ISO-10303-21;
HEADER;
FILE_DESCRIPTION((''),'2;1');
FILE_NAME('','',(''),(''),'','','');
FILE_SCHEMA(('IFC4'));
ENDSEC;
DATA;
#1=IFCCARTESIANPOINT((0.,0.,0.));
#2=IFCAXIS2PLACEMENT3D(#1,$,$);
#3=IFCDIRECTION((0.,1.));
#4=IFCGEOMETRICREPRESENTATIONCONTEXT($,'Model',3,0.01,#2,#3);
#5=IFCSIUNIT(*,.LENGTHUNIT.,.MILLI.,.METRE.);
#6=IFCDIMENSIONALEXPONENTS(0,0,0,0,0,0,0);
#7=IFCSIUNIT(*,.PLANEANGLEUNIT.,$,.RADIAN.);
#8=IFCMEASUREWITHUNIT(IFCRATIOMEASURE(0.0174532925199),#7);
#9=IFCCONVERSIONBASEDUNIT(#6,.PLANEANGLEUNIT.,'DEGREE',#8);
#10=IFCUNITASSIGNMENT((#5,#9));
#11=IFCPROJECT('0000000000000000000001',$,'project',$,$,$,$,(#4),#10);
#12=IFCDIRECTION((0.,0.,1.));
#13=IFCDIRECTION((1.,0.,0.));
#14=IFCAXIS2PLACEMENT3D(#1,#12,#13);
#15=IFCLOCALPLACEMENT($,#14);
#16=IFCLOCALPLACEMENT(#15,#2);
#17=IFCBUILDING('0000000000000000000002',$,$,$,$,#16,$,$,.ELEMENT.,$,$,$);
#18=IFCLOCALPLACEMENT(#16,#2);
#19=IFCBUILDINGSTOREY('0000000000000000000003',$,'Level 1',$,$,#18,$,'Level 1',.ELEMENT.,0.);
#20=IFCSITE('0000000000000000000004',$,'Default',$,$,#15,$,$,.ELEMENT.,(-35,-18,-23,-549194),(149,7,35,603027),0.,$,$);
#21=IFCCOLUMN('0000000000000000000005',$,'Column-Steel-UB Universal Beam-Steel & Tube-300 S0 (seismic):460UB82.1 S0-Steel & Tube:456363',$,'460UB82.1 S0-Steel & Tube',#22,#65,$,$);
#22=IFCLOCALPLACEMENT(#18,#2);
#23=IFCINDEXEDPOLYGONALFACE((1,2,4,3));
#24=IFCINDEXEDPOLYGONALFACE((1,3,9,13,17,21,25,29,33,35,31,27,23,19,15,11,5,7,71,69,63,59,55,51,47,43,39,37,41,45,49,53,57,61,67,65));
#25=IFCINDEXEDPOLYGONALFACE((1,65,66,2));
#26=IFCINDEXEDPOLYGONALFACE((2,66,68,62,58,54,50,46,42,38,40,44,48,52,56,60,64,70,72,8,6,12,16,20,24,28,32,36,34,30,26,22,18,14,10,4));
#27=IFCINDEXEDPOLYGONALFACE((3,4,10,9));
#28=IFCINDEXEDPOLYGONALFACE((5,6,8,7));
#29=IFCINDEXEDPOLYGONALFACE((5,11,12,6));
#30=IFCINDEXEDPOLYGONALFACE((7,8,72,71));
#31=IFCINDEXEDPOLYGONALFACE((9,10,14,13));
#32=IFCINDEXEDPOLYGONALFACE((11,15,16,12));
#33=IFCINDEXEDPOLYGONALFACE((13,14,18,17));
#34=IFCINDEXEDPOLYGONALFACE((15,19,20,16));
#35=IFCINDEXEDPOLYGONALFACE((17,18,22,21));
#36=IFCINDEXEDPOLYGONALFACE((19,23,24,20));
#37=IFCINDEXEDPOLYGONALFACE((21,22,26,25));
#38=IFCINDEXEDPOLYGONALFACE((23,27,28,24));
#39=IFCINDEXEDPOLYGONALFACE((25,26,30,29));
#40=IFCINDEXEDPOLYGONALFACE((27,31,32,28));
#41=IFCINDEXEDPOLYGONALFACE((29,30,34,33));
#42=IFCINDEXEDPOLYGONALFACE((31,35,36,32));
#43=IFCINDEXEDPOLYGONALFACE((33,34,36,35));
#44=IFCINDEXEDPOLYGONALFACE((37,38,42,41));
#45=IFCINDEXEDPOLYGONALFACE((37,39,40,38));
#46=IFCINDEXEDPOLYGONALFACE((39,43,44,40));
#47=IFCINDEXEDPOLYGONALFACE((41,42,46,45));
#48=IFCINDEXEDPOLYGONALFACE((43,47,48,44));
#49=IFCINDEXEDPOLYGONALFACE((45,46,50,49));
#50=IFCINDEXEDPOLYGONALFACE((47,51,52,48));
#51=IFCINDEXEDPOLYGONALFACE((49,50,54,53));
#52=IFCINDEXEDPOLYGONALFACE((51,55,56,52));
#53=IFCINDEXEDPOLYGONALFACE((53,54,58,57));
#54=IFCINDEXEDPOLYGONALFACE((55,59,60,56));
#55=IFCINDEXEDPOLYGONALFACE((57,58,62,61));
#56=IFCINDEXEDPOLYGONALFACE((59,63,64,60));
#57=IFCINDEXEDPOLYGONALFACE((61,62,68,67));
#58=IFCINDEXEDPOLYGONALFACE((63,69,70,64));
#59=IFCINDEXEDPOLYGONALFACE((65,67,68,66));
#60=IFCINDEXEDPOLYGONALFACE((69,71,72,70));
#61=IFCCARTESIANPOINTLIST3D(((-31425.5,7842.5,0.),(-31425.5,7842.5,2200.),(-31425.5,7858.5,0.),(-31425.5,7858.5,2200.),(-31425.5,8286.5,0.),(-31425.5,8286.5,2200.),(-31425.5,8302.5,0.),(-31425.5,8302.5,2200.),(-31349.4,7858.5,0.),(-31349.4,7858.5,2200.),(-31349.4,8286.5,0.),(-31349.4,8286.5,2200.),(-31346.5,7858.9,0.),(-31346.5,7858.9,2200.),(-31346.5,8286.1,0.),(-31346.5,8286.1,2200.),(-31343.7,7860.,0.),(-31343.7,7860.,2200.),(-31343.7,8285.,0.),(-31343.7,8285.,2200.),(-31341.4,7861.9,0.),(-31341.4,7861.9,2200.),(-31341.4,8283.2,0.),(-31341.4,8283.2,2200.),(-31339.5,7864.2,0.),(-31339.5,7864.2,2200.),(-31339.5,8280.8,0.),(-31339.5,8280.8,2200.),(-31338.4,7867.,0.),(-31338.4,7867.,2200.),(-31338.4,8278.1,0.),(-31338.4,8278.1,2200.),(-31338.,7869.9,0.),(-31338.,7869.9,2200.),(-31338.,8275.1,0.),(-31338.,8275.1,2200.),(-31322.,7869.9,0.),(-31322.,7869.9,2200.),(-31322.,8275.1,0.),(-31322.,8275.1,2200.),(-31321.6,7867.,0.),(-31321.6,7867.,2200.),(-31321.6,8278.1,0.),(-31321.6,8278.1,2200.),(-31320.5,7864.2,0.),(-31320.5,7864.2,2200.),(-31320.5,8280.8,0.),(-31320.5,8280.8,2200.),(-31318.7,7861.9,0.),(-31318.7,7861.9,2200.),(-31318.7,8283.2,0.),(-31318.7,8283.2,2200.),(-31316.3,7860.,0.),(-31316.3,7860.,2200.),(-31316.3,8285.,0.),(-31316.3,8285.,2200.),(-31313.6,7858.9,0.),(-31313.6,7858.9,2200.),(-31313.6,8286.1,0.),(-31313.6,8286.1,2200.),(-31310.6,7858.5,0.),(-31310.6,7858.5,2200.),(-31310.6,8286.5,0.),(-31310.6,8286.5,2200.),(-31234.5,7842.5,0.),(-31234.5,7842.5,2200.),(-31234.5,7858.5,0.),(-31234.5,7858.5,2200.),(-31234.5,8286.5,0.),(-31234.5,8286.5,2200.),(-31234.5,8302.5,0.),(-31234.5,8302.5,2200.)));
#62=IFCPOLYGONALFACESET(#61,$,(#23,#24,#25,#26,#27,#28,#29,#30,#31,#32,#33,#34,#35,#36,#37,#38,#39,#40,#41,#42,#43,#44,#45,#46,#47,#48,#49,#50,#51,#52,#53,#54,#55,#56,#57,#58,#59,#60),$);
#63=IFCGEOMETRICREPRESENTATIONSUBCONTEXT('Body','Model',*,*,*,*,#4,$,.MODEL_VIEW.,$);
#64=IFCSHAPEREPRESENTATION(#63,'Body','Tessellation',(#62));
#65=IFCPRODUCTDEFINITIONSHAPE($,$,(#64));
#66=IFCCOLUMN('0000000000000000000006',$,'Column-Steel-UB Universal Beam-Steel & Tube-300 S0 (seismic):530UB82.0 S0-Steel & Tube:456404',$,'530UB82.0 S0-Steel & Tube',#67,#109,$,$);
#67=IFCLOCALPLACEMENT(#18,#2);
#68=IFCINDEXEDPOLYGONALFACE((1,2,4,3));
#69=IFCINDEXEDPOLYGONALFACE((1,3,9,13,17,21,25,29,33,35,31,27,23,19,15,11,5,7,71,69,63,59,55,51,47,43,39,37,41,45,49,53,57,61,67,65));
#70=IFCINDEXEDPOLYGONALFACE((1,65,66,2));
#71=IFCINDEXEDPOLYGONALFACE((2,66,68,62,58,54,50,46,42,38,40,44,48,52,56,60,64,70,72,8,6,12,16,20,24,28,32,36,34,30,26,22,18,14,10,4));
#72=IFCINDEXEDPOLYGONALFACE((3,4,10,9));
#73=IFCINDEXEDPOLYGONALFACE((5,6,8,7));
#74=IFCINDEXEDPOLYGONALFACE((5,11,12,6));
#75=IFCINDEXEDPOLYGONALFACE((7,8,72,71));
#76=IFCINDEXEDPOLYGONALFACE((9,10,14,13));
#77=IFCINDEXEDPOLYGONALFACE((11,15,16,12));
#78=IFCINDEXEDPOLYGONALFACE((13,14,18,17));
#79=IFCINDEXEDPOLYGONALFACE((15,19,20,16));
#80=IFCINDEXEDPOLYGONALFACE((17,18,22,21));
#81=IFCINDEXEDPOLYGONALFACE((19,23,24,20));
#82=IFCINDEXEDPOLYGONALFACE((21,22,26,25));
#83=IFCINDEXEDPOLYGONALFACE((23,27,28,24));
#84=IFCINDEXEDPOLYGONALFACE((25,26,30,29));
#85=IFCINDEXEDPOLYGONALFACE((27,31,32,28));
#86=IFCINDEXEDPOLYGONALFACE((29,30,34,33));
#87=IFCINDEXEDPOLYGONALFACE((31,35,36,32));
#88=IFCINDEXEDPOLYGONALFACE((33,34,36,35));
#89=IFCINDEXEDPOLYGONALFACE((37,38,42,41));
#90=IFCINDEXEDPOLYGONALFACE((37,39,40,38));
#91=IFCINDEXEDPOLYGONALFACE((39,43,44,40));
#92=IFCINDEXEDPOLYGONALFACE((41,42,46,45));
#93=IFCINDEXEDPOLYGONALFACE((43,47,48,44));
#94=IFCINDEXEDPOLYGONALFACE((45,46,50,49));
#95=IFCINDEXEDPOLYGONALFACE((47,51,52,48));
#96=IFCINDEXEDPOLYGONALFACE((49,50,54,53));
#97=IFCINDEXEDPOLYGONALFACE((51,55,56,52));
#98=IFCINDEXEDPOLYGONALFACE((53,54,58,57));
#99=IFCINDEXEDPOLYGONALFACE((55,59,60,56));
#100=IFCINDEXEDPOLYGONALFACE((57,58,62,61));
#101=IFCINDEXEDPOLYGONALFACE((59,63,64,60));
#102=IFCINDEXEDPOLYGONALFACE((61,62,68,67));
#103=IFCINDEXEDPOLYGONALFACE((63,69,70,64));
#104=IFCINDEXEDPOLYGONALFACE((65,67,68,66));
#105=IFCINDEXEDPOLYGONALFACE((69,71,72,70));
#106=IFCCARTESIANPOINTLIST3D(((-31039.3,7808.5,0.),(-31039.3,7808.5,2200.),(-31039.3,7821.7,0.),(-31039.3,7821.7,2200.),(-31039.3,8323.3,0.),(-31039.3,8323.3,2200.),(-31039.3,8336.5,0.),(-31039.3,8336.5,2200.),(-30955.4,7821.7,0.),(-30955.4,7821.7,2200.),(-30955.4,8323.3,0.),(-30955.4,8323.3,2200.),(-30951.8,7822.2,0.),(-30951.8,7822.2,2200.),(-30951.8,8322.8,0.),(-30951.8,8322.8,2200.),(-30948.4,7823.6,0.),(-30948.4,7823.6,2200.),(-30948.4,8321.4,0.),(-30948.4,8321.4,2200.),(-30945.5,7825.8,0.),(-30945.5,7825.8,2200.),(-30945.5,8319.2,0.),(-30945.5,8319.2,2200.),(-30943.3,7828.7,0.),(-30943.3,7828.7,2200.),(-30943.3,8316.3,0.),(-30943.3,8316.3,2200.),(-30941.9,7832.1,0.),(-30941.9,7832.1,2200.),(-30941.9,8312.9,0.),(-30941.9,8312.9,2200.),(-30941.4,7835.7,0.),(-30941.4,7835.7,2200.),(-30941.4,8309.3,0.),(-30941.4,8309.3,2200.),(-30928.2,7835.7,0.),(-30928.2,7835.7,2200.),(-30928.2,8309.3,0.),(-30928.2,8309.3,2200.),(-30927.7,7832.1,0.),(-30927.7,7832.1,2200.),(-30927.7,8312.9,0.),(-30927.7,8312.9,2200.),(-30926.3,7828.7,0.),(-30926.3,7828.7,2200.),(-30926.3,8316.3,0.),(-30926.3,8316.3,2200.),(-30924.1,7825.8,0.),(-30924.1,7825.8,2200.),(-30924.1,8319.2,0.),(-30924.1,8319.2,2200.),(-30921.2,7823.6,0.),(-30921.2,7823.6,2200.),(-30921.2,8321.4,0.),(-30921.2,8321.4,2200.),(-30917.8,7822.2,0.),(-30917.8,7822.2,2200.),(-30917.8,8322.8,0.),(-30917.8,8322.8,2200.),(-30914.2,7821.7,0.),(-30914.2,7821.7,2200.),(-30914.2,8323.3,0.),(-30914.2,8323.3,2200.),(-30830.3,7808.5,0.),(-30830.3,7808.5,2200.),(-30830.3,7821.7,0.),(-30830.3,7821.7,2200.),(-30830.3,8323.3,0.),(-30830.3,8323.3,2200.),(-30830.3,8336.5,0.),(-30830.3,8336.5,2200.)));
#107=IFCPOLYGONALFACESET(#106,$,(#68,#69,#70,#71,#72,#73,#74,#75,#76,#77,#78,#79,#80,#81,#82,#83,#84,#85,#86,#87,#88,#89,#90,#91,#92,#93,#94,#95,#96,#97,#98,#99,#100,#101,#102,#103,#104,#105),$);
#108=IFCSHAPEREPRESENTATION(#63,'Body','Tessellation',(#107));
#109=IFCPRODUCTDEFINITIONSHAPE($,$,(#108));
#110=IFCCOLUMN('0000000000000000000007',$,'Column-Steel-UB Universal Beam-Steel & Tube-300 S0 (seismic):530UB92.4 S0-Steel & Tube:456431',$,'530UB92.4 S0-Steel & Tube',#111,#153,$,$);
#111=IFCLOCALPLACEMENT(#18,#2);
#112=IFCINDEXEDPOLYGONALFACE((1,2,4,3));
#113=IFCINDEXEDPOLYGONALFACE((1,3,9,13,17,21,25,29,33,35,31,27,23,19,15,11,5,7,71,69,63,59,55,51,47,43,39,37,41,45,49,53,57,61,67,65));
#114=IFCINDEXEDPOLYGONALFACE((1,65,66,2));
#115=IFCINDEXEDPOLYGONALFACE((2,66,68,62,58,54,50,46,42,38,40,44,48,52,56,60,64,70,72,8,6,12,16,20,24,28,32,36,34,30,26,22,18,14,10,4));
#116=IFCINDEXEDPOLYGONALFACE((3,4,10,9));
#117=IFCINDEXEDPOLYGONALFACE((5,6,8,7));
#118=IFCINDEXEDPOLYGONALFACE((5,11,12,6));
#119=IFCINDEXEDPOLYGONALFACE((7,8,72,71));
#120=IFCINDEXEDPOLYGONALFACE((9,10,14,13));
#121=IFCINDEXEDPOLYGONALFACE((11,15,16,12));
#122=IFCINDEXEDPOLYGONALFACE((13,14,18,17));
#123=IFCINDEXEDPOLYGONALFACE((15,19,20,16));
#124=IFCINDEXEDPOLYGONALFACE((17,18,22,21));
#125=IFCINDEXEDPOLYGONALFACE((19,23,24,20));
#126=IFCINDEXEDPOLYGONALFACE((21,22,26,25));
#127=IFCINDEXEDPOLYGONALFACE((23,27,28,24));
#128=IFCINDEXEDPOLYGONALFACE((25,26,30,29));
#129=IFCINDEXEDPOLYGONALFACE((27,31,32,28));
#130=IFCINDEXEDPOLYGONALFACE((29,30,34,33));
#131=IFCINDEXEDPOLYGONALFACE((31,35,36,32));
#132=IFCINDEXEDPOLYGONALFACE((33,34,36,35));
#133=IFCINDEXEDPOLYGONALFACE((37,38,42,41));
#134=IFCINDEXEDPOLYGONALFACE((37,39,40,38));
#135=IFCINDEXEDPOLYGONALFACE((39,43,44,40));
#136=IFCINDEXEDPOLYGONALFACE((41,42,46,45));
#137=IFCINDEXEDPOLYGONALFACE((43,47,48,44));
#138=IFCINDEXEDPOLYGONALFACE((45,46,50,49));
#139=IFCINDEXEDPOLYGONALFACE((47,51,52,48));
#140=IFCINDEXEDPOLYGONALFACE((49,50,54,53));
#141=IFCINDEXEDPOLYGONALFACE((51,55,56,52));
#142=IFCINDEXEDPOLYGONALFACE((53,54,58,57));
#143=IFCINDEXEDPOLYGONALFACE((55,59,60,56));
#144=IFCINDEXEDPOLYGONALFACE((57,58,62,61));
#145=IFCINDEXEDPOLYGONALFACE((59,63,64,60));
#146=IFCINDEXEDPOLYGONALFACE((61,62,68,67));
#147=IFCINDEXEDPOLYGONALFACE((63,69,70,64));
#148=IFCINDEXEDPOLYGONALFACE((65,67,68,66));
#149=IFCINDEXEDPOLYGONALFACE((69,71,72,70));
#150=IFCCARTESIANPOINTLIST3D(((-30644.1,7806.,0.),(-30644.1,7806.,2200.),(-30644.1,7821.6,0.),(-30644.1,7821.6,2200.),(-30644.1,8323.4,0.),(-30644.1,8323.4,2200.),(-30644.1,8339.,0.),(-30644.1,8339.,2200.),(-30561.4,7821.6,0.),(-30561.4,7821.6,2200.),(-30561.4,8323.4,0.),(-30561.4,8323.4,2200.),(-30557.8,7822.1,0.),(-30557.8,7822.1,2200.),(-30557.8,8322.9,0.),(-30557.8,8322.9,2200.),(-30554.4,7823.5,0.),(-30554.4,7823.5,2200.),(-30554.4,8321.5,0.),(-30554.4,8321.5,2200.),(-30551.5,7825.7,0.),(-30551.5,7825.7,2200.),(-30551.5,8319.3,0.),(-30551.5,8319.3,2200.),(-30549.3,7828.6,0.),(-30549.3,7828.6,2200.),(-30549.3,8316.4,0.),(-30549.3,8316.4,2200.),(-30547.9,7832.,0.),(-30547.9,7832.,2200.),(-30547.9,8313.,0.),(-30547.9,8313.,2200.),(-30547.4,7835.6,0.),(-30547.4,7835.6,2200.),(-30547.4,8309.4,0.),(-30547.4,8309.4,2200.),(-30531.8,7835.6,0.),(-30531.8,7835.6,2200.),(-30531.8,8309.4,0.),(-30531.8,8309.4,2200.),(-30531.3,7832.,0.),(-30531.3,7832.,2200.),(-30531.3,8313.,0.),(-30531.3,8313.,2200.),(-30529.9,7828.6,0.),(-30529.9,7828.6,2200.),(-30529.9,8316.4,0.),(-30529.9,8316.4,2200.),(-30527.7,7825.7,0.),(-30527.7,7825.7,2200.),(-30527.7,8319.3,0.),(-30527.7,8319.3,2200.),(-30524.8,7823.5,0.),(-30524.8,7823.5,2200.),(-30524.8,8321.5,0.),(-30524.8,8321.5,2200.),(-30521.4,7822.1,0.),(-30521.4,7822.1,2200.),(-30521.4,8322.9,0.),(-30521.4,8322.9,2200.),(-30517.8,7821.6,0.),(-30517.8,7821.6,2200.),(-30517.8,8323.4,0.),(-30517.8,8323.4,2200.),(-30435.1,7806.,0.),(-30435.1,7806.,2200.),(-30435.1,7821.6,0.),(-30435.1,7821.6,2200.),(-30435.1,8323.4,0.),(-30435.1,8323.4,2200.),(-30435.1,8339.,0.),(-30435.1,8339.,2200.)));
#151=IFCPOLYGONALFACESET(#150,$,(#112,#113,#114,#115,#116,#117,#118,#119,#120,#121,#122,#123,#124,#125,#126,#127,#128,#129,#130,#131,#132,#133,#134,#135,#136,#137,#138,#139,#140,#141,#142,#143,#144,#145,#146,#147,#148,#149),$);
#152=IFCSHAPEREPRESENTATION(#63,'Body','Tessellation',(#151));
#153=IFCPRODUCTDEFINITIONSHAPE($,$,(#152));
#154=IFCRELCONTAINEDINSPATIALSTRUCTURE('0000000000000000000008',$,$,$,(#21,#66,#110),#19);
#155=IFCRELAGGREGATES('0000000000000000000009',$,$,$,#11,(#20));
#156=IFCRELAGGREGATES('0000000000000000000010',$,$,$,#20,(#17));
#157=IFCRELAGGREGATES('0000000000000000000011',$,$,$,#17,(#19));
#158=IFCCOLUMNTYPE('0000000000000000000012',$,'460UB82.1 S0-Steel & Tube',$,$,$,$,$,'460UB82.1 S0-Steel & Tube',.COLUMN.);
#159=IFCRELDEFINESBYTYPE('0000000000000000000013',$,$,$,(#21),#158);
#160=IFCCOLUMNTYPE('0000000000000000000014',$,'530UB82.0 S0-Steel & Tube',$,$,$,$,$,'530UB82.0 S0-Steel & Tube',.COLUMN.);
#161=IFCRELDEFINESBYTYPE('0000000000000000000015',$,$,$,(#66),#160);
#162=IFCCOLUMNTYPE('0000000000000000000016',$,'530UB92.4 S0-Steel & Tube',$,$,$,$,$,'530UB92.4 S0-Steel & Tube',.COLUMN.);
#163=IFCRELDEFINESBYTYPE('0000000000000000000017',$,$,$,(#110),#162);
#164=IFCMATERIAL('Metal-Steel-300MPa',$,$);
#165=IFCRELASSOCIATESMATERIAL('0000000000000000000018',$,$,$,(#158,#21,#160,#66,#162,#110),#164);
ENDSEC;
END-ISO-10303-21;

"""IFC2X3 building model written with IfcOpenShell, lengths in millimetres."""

from ifc_helpers import new_model, entity, si_unit, converted_unit, direction, frame, frame_2d, origin, origin_with_axes, place, context, subcontext, project, spatial, polyline, circle_curve, parameter, trimmed, segment, composite_curve, outline, extrude, source, transform, mapped, material, type_object, type_shapes, element, save


model = new_model("IFC2X3")

# Units and contexts
model_context = context("Model", 3, precision=0.01, world=origin(), true_north=direction((0.0, 1.0)))
body_context = subcontext(model_context, "Body", "Model", "MODEL_VIEW")
ifc_project = project(units=[si_unit("LENGTHUNIT", "METRE", prefix="MILLI"), converted_unit("PLANEANGLEUNIT", "DEGREE", entity("IfcRatioMeasure", 0.0174532925199), si_unit("PLANEANGLEUNIT", "RADIAN"), dimensions=[0, 0, 0, 0, 0, 0, 0])], contexts=[model_context])

# Site, building, storey
site_placement = place(None, origin_with_axes())
site = spatial("IfcSite", under=ifc_project, at=site_placement, Name="Default", CompositionType="ELEMENT", RefLatitude=(-35, -18, -23, -549194), RefLongitude=(149, 7, 35, 603027), RefElevation=0.0)
building_placement = place(site_placement, origin())
building = spatial("IfcBuilding", under=site, at=building_placement, CompositionType="ELEMENT")
storey_placement = place(building_placement, origin())
storey = spatial("IfcBuildingStorey", under=building, at=storey_placement, Name="Level 1", LongName="Level 1", CompositionType="ELEMENT", Elevation=0.0)

# Columns
ifc_material = material(Name="Metal-Steel-300MPa")
column_type_1 = type_object("IfcColumnType", Name="460UB82.1 S0-Steel & Tube", ElementType="460UB82.1 S0-Steel & Tube", PredefinedType="COLUMN", material=ifc_material)
shared_shape_1 = source(origin(), body_context, "Body", "SweptSolid", [
    extrude(outline(composite_curve([segment(polyline([(214.0, -95.5), (230.0, -95.5)]), True, "CONTINUOUS"), segment(polyline([(230.0, -95.5), (230.0, 95.5)]), True, "CONTINUOUS"), segment(polyline([(230.0, 95.5), (214.0, 95.5)]), True, "CONTINUOUS"), segment(polyline([(214.0, 95.5), (214.0, 19.4)]), True, "CONTINUOUS"), segment(trimmed(circle_curve(frame_2d((202.6, 19.4), x_axis=(1.0, 0.0)), 11.4), [parameter(270.0)], [parameter(0.0)], True, "PARAMETER"), False, "CONTINUOUS"), segment(polyline([(202.6, 8.0), (-202.6, 8.0)]), True, "CONTINUOUS"), segment(trimmed(circle_curve(frame_2d((-202.6, 19.4), x_axis=(0.0, -1.0)), 11.4), [parameter(270.0)], [parameter(0.0)], True, "PARAMETER"), False, "CONTINUOUS"), segment(polyline([(-214.0, 19.4), (-214.0, 95.5)]), True, "CONTINUOUS"), segment(polyline([(-214.0, 95.5), (-230.0, 95.5)]), True, "CONTINUOUS"), segment(polyline([(-230.0, 95.5), (-230.0, -95.5)]), True, "CONTINUOUS"), segment(polyline([(-230.0, -95.5), (-214.0, -95.5)]), True, "CONTINUOUS"), segment(polyline([(-214.0, -95.5), (-214.0, -19.4)]), True, "CONTINUOUS"), segment(trimmed(circle_curve(frame_2d((-202.6, -19.4), x_axis=(-1.0, 0.0)), 11.4), [parameter(270.0)], [parameter(0.0)], True, "PARAMETER"), False, "CONTINUOUS"), segment(polyline([(-202.6, -8.0), (202.6, -8.0)]), True, "CONTINUOUS"), segment(trimmed(circle_curve(frame_2d((202.6, -19.4), x_axis=(0.0, 1.0)), 11.4), [parameter(270.0)], [parameter(0.0)], True, "PARAMETER"), False, "CONTINUOUS"), segment(polyline([(214.0, -19.4), (214.0, -95.5)]), True, "CONTINUOUS")], self_intersect=False)), frame((0.0, 0.0, 0.0), z_axis=(0.0, 0.0, 1.0), x_axis=(0.0, -1.0, 0.0)), (0.0, 0.0, 1.0), 2200.0),
])
type_shapes(column_type_1, [shared_shape_1])
column_1_placement = place(storey_placement, frame((-31330.0, 8072.5, 0.0)))
element("IfcColumn", 1, at=column_1_placement, inside=storey, type_object=column_type_1, material=ifc_material, Name="Column-Steel-UB Universal Beam-Steel & Tube-300 S0 (seismic):460UB82.1 S0-Steel & Tube:456363", ObjectType="460UB82.1 S0-Steel & Tube", context=body_context, shape_type="MappedRepresentation", body=[
    mapped(shared_shape_1, transform((0.0, 0.0, 0.0), scale=1.0)),
])
column_type_2 = type_object("IfcColumnType", Name="530UB82.0 S0-Steel & Tube", ElementType="530UB82.0 S0-Steel & Tube", PredefinedType="COLUMN", material=ifc_material)
shared_shape_2 = source(origin(), body_context, "Body", "SweptSolid", [
    extrude(outline(composite_curve([segment(polyline([(250.8, -104.5), (264.0, -104.5)]), True, "CONTINUOUS"), segment(polyline([(264.0, -104.5), (264.0, 104.5)]), True, "CONTINUOUS"), segment(polyline([(264.0, 104.5), (250.8, 104.5)]), True, "CONTINUOUS"), segment(polyline([(250.8, 104.5), (250.8, 20.6)]), True, "CONTINUOUS"), segment(trimmed(circle_curve(frame_2d((236.8, 20.6), x_axis=(1.0, 0.0)), 14.0), [parameter(270.0)], [parameter(0.0)], True, "PARAMETER"), False, "CONTINUOUS"), segment(polyline([(236.8, 6.6), (-236.8, 6.6)]), True, "CONTINUOUS"), segment(trimmed(circle_curve(frame_2d((-236.8, 20.6), x_axis=(0.0, -1.0)), 14.0), [parameter(270.0)], [parameter(0.0)], True, "PARAMETER"), False, "CONTINUOUS"), segment(polyline([(-250.8, 20.6), (-250.8, 104.5)]), True, "CONTINUOUS"), segment(polyline([(-250.8, 104.5), (-264.0, 104.5)]), True, "CONTINUOUS"), segment(polyline([(-264.0, 104.5), (-264.0, -104.5)]), True, "CONTINUOUS"), segment(polyline([(-264.0, -104.5), (-250.8, -104.5)]), True, "CONTINUOUS"), segment(polyline([(-250.8, -104.5), (-250.8, -20.6)]), True, "CONTINUOUS"), segment(trimmed(circle_curve(frame_2d((-236.8, -20.6), x_axis=(-1.0, 0.0)), 14.0), [parameter(270.0)], [parameter(0.0)], True, "PARAMETER"), False, "CONTINUOUS"), segment(polyline([(-236.8, -6.6), (236.8, -6.6)]), True, "CONTINUOUS"), segment(trimmed(circle_curve(frame_2d((236.8, -20.6), x_axis=(0.0, 1.0)), 14.0), [parameter(270.0)], [parameter(0.0)], True, "PARAMETER"), False, "CONTINUOUS"), segment(polyline([(250.8, -20.6), (250.8, -104.5)]), True, "CONTINUOUS")], self_intersect=False)), frame((0.0, 0.0, 0.0), z_axis=(0.0, 0.0, 1.0), x_axis=(0.0, -1.0, 0.0)), (0.0, 0.0, 1.0), 2200.0),
])
type_shapes(column_type_2, [shared_shape_2])
column_2_placement = place(storey_placement, frame((-30934.8, 8072.5, 0.0)))
element("IfcColumn", 2, at=column_2_placement, inside=storey, type_object=column_type_2, material=ifc_material, Name="Column-Steel-UB Universal Beam-Steel & Tube-300 S0 (seismic):530UB82.0 S0-Steel & Tube:456404", ObjectType="530UB82.0 S0-Steel & Tube", context=body_context, shape_type="MappedRepresentation", body=[
    mapped(shared_shape_2, transform((0.0, 0.0, 0.0), scale=1.0)),
])
column_type_3 = type_object("IfcColumnType", Name="530UB92.4 S0-Steel & Tube", ElementType="530UB92.4 S0-Steel & Tube", PredefinedType="COLUMN", material=ifc_material)
shared_shape_3 = source(origin(), body_context, "Body", "SweptSolid", [
    extrude(outline(composite_curve([segment(polyline([(250.9, -104.5), (266.5, -104.5)]), True, "CONTINUOUS"), segment(polyline([(266.5, -104.5), (266.5, 104.5)]), True, "CONTINUOUS"), segment(polyline([(266.5, 104.5), (250.9, 104.5)]), True, "CONTINUOUS"), segment(polyline([(250.9, 104.5), (250.9, 21.8)]), True, "CONTINUOUS"), segment(trimmed(circle_curve(frame_2d((236.9, 21.8), x_axis=(1.0, 0.0)), 14.0), [parameter(270.0)], [parameter(0.0)], True, "PARAMETER"), False, "CONTINUOUS"), segment(polyline([(236.9, 7.8), (-236.9, 7.8)]), True, "CONTINUOUS"), segment(trimmed(circle_curve(frame_2d((-236.9, 21.8), x_axis=(0.0, -1.0)), 14.0), [parameter(270.0)], [parameter(0.0)], True, "PARAMETER"), False, "CONTINUOUS"), segment(polyline([(-250.9, 21.8), (-250.9, 104.5)]), True, "CONTINUOUS"), segment(polyline([(-250.9, 104.5), (-266.5, 104.5)]), True, "CONTINUOUS"), segment(polyline([(-266.5, 104.5), (-266.5, -104.5)]), True, "CONTINUOUS"), segment(polyline([(-266.5, -104.5), (-250.9, -104.5)]), True, "CONTINUOUS"), segment(polyline([(-250.9, -104.5), (-250.9, -21.8)]), True, "CONTINUOUS"), segment(trimmed(circle_curve(frame_2d((-236.9, -21.8), x_axis=(-1.0, 0.0)), 14.0), [parameter(270.0)], [parameter(0.0)], True, "PARAMETER"), False, "CONTINUOUS"), segment(polyline([(-236.9, -7.8), (236.9, -7.8)]), True, "CONTINUOUS"), segment(trimmed(circle_curve(frame_2d((236.9, -21.8), x_axis=(0.0, 1.0)), 14.0), [parameter(270.0)], [parameter(0.0)], True, "PARAMETER"), False, "CONTINUOUS"), segment(polyline([(250.9, -21.8), (250.9, -104.5)]), True, "CONTINUOUS")], self_intersect=False)), frame((0.0, 0.0, 0.0), z_axis=(0.0, 0.0, 1.0), x_axis=(0.0, -1.0, 0.0)), (0.0, 0.0, 1.0), 2200.0),
])
type_shapes(column_type_3, [shared_shape_3])
column_3_placement = place(storey_placement, frame((-30539.6, 8072.5, 0.0)))
element("IfcColumn", 3, at=column_3_placement, inside=storey, type_object=column_type_3, material=ifc_material, Name="Column-Steel-UB Universal Beam-Steel & Tube-300 S0 (seismic):530UB92.4 S0-Steel & Tube:456431", ObjectType="530UB92.4 S0-Steel & Tube", context=body_context, shape_type="MappedRepresentation", body=[
    mapped(shared_shape_3, transform((0.0, 0.0, 0.0), scale=1.0)),
])

save(model, "model.ifc")
